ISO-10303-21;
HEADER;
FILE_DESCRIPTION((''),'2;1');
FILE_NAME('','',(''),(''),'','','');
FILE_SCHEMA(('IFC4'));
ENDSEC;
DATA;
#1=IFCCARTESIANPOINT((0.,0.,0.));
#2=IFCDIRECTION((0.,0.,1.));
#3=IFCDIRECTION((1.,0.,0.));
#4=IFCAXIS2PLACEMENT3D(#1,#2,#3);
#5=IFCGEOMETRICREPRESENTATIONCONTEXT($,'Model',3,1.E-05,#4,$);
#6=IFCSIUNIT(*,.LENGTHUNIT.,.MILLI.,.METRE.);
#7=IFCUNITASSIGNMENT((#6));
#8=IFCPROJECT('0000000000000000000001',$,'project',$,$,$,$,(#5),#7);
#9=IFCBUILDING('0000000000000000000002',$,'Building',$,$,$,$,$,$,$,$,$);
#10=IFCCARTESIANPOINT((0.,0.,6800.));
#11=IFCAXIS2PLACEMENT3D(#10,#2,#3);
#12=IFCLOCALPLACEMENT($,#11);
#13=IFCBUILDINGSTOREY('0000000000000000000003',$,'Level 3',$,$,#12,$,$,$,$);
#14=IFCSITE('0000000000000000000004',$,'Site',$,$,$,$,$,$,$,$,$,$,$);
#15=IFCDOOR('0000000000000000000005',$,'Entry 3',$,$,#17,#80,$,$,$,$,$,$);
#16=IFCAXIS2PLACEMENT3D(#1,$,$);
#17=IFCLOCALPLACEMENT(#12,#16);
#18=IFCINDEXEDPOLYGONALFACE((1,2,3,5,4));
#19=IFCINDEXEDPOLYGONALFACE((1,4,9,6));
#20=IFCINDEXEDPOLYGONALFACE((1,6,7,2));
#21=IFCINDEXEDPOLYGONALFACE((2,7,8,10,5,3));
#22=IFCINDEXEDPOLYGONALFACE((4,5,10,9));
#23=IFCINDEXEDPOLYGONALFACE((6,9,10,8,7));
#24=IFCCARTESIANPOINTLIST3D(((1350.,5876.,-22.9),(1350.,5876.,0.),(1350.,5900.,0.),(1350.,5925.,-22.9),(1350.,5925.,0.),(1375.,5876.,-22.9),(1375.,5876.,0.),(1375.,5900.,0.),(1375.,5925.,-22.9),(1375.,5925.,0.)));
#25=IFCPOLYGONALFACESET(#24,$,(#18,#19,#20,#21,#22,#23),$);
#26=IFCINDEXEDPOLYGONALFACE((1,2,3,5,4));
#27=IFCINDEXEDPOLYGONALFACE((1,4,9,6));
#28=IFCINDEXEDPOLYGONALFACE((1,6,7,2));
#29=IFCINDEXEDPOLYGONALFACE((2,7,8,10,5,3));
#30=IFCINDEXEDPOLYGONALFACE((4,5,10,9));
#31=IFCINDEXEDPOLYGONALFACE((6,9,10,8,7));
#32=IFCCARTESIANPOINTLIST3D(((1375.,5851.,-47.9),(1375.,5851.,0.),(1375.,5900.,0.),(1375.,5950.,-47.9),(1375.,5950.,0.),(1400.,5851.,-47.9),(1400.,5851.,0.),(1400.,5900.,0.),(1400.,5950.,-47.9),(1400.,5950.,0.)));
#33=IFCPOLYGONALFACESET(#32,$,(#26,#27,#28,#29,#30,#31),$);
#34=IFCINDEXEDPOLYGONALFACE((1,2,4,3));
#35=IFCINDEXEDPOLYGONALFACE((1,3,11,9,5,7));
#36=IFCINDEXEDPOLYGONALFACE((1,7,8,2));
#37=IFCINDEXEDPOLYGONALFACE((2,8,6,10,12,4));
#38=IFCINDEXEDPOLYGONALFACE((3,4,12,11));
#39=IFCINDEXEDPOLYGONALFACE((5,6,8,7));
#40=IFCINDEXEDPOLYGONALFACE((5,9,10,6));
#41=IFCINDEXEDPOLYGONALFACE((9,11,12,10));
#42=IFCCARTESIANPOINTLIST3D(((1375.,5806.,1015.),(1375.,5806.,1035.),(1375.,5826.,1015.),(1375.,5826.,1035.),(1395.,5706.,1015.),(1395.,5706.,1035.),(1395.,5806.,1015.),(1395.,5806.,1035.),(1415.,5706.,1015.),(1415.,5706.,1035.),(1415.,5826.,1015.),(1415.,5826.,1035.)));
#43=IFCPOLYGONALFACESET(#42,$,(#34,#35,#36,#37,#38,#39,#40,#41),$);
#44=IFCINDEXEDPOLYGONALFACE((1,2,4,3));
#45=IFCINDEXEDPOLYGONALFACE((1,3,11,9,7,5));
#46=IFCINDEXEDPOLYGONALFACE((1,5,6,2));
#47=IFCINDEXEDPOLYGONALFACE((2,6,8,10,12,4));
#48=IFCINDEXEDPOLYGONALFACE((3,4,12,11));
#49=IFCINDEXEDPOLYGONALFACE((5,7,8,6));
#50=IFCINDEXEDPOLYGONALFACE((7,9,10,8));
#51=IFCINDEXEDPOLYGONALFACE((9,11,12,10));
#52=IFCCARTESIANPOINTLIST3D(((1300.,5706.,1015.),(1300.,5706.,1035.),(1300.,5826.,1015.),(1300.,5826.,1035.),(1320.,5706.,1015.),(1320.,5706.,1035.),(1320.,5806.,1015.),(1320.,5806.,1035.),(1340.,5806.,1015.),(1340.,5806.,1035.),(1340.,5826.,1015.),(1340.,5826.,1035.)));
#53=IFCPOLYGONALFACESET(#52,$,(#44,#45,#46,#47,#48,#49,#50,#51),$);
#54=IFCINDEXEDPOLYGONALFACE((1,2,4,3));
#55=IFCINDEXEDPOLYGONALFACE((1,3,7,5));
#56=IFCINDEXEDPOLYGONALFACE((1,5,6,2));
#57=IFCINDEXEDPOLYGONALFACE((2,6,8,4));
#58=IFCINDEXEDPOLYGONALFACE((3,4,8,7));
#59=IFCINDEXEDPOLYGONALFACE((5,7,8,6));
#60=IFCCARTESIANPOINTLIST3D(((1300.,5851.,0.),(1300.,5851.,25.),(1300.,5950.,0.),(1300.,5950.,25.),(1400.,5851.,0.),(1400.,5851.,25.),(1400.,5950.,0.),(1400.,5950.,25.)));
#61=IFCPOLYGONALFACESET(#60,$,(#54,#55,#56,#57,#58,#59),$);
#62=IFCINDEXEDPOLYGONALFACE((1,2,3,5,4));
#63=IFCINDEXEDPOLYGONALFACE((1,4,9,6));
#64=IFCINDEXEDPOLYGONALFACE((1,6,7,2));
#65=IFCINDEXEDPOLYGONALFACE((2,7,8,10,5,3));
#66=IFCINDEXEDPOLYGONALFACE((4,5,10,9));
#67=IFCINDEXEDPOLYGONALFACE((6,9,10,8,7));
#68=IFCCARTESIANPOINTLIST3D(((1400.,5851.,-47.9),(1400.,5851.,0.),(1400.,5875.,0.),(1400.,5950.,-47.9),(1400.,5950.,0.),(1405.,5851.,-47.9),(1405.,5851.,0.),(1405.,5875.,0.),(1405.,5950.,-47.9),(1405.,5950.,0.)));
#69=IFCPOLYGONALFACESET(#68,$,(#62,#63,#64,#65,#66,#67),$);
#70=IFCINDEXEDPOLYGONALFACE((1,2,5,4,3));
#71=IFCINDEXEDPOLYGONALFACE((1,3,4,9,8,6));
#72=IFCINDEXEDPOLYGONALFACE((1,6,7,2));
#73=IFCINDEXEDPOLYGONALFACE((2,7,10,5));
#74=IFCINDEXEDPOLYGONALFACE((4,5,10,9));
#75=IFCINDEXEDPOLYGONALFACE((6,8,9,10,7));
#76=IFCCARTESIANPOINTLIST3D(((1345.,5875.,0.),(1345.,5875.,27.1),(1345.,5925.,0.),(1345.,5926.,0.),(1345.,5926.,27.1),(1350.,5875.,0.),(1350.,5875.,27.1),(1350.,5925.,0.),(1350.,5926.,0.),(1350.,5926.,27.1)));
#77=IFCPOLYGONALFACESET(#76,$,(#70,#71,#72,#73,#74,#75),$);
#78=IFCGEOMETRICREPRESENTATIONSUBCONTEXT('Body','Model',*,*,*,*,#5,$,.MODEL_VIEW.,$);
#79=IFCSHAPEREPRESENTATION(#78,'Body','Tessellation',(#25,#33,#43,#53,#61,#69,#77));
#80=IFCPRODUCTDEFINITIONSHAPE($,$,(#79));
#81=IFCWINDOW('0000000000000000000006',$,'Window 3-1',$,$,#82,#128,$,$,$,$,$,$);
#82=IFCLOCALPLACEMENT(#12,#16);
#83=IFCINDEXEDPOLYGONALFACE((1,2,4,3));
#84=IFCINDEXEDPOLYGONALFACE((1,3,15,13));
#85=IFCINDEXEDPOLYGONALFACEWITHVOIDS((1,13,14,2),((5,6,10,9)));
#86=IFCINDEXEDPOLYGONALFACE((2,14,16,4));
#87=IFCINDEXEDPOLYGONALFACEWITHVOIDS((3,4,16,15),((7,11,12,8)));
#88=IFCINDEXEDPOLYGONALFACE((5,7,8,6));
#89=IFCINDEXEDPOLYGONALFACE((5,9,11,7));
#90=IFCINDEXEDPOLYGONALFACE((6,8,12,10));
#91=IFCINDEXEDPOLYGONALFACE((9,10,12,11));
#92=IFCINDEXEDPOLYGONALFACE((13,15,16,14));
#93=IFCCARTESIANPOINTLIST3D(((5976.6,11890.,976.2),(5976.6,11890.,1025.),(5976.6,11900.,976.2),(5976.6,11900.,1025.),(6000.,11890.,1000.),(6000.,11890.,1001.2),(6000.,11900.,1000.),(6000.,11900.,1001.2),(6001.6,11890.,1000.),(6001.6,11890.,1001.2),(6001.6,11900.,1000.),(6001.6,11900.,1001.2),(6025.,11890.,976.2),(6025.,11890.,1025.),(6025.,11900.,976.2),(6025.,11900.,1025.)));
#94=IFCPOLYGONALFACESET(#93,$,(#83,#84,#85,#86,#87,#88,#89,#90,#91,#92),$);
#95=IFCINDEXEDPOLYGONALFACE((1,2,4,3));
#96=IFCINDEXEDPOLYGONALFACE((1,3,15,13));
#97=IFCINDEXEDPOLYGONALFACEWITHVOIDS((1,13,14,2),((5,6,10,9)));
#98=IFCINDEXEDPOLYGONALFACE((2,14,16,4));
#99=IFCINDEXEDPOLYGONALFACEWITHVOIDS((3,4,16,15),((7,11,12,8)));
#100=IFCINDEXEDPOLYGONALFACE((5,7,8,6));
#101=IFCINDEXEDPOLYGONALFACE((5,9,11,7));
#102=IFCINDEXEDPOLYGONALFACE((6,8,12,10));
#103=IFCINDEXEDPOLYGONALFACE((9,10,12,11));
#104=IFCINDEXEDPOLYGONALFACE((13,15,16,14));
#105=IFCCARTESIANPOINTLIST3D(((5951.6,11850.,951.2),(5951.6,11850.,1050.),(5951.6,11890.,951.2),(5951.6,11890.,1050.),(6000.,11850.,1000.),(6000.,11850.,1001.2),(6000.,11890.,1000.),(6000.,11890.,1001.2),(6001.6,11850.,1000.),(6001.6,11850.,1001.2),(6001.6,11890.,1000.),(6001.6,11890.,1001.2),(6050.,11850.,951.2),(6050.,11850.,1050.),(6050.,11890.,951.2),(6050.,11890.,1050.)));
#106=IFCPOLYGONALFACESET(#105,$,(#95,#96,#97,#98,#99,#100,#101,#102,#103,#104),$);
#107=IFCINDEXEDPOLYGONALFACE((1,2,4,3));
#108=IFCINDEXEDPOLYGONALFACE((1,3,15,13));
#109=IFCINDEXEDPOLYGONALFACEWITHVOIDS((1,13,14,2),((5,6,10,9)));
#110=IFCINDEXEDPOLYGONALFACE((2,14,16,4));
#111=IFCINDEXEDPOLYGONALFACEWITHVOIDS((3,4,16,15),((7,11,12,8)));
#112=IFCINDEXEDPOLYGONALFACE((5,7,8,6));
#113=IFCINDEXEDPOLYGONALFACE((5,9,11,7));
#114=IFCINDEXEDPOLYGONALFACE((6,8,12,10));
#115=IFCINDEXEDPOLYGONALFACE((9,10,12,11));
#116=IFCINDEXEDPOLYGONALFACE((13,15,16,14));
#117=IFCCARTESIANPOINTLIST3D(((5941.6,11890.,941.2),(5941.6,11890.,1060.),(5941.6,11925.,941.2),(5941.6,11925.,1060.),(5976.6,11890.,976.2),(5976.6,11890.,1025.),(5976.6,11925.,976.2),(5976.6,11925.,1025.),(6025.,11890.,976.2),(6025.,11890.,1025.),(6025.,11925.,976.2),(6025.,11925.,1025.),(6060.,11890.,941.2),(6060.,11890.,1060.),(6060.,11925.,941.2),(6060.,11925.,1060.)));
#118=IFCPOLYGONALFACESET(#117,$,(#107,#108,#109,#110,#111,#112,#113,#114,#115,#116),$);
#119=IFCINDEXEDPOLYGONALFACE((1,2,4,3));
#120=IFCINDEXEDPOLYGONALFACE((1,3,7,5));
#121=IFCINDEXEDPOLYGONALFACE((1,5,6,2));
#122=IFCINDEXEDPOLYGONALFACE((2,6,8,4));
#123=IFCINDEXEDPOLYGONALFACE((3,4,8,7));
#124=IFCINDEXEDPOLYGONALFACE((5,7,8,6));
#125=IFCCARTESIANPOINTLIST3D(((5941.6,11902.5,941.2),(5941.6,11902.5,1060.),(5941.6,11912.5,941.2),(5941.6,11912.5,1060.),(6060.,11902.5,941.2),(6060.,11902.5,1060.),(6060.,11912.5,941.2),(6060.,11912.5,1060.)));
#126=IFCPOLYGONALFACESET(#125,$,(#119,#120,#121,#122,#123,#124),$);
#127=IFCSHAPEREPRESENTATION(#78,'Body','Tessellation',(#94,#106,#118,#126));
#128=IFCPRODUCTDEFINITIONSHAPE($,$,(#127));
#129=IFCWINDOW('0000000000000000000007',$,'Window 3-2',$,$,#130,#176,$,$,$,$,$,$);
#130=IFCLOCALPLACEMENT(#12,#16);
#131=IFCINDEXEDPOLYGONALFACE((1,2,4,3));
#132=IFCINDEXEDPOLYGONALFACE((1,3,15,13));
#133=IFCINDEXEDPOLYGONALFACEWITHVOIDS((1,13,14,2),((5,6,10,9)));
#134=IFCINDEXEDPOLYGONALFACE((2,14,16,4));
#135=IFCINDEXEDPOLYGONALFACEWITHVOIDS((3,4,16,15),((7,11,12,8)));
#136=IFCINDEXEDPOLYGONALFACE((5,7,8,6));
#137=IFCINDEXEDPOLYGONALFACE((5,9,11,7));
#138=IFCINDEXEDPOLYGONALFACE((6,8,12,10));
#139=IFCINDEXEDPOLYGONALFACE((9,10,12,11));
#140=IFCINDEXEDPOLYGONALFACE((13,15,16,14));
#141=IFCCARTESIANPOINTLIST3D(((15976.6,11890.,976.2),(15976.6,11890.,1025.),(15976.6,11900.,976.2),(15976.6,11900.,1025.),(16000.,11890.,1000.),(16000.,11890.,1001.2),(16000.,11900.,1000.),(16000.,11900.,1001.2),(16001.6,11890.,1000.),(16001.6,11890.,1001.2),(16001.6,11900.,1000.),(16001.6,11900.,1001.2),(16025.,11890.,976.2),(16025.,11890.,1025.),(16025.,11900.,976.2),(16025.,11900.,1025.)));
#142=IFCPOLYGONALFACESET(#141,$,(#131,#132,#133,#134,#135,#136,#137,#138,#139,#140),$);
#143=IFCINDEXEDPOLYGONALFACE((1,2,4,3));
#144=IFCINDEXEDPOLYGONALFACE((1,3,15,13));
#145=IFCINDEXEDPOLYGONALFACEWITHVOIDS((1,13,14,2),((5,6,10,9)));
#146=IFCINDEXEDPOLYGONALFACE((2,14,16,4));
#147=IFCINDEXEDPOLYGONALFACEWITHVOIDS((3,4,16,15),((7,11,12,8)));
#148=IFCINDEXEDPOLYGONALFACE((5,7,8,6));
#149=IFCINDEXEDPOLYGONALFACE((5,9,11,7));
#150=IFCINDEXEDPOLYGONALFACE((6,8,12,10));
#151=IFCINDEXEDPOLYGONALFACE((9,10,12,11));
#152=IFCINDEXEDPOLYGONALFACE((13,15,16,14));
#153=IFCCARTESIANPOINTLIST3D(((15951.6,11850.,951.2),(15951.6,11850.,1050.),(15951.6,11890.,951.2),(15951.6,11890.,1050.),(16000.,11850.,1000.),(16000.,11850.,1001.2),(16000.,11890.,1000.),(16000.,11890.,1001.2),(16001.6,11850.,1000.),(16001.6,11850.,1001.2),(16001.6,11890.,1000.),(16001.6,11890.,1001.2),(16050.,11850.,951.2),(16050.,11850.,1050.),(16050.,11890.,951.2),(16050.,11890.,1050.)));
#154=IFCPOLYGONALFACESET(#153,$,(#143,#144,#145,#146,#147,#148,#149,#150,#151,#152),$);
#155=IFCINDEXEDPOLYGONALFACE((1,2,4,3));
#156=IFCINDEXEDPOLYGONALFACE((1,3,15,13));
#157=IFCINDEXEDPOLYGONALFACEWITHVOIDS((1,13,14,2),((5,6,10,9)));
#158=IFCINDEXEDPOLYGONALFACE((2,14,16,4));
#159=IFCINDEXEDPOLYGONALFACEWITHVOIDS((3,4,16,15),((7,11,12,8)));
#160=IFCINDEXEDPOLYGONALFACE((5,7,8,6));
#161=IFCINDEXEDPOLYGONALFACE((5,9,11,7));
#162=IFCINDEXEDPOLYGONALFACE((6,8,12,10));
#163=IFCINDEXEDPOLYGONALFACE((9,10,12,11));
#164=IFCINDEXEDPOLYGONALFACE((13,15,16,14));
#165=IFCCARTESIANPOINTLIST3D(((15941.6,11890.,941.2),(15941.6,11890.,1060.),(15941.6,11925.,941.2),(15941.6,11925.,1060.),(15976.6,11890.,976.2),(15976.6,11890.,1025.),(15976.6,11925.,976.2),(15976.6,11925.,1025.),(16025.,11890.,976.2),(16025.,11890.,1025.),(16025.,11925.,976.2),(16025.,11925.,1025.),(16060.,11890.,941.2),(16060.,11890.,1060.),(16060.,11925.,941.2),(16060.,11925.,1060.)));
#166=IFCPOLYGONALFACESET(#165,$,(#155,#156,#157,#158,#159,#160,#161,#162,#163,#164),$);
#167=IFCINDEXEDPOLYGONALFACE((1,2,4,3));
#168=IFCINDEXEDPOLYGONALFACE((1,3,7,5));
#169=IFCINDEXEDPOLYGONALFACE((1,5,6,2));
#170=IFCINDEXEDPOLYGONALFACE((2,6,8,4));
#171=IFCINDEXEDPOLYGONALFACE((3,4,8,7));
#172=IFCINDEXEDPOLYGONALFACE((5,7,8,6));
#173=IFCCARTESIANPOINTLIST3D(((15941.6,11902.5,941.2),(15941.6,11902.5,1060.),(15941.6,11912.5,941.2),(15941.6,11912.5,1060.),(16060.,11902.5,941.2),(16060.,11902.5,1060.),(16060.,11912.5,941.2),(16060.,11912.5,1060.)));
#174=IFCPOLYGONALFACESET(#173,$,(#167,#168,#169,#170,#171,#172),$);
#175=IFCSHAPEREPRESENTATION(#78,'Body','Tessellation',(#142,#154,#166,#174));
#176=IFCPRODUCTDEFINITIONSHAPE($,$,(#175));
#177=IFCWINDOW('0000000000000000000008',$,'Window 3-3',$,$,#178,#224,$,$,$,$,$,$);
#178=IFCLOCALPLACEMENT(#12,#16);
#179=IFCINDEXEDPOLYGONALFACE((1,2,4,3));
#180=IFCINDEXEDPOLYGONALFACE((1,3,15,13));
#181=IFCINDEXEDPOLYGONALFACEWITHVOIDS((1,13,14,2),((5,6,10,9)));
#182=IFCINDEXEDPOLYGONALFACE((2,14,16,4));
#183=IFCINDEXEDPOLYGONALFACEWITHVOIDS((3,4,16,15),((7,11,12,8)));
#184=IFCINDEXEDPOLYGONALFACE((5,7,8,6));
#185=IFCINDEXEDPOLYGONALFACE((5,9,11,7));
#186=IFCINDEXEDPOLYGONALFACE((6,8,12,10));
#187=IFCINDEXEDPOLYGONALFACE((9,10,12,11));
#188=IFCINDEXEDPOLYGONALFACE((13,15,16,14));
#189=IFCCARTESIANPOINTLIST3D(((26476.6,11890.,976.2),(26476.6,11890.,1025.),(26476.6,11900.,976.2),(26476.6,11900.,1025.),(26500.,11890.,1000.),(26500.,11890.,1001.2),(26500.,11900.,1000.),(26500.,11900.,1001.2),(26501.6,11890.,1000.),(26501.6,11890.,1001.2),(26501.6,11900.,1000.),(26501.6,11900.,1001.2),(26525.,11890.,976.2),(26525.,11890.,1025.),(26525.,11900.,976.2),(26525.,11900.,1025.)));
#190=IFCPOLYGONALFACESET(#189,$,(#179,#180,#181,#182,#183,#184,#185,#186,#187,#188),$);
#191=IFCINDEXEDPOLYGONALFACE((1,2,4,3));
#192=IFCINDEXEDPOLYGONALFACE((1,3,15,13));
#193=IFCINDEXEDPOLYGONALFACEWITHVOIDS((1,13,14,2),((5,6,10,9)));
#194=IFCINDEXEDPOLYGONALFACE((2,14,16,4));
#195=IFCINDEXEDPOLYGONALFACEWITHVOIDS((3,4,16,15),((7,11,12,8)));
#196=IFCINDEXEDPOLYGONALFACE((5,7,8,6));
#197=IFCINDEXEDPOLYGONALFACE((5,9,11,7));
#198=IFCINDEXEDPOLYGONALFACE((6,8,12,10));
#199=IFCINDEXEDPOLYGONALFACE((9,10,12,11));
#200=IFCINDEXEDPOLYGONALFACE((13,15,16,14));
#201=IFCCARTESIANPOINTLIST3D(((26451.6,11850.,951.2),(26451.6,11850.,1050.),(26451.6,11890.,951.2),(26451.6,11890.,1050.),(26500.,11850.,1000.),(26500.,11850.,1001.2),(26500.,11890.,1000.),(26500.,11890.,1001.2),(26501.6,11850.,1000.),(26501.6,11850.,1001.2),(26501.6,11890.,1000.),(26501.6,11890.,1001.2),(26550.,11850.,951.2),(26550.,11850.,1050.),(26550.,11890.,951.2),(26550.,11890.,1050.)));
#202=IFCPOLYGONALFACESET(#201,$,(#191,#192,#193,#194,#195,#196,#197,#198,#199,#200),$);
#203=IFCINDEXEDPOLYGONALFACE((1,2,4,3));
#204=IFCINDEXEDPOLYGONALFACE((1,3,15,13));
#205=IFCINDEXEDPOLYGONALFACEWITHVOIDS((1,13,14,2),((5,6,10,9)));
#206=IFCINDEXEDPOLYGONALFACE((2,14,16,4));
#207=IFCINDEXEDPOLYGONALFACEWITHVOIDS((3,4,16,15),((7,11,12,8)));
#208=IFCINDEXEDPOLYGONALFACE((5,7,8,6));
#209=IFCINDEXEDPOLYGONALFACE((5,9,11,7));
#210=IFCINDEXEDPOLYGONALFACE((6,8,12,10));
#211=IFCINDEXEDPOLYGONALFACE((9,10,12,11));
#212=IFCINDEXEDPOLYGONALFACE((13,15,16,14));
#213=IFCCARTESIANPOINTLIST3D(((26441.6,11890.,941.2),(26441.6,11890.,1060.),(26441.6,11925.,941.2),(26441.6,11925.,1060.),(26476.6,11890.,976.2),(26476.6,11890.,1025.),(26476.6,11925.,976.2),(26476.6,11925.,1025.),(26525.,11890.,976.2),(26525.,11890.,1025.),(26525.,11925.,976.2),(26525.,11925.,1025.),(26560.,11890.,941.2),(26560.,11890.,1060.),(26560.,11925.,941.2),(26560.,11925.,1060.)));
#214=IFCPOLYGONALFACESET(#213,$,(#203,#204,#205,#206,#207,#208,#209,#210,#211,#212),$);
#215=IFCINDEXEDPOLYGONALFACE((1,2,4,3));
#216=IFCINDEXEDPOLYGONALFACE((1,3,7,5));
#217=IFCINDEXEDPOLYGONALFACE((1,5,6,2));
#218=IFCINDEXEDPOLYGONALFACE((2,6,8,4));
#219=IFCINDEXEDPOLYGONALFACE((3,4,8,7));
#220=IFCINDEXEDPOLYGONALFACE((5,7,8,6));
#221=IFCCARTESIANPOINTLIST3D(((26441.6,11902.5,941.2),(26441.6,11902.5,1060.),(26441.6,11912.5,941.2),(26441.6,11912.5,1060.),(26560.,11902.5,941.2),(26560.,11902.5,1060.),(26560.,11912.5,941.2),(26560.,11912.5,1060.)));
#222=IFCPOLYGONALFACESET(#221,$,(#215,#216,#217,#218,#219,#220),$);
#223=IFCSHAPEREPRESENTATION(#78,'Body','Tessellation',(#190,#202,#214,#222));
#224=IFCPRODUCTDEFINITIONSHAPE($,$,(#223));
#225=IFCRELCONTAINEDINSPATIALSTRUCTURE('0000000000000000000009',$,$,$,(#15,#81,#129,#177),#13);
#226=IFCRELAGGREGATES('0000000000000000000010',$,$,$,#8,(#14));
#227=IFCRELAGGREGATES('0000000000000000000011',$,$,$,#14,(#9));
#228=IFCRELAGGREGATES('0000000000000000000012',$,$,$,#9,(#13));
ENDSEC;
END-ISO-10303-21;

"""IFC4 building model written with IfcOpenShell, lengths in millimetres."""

from ifc_helpers import new_model, si_unit, frame, origin_with_axes, place, context, subcontext, project, spatial, line, indexed_curve, outline, extrude, element, save


model = new_model("IFC4")

# Units and contexts
model_context = context("Model", 3, precision=1e-05, world=origin_with_axes())
body_context = subcontext(model_context, "Body", "Model", "MODEL_VIEW")
ifc_project = project(units=[si_unit("LENGTHUNIT", "METRE", prefix="MILLI")], contexts=[model_context])

# Site, building, storey
site = spatial("IfcSite", under=ifc_project, Name="Site")
building = spatial("IfcBuilding", under=site, Name="Building")
storey_placement = place(None, frame((0.0, 0.0, 6800.0), z_axis=(0.0, 0.0, 1.0), x_axis=(1.0, 0.0, 0.0)))
storey = spatial("IfcBuildingStorey", under=building, at=storey_placement, Name="Level 3")

# Door
door_1_placement = place(storey_placement, frame((1400.0, 5900.0, 0.0), z_axis=(0.0, 0.0, 1.0), x_axis=(0.0, 1.0, 0.0)))
element("IfcDoor", 1, at=door_1_placement, inside=storey, Name="Entry 3", context=body_context, shape_type="SweptSolid", body=[
    extrude(outline(indexed_curve([(0.0, 0.0), (0.0, 2.1), (1.0, 2.1), (1.0, 0.0), (-24.0, 0.0), (-24.0, -22.9), (25.0, -22.9), (25.0, 0.0)], segments=[line(1, 2, 3, 4, 5, 6, 7, 8, 1)])), frame((0.0, 25.0, 0.0), z_axis=(0.0, -1.0, 0.0), x_axis=(1.0, 0.0, 0.0)), (0.0, 0.0, -1.0), 25.0),
    extrude(outline(indexed_curve([(0.0, 0.0), (0.0, 2.1), (1.0, 2.1), (1.0, 0.0), (-49.0, 0.0), (-49.0, -47.9), (50.0, -47.9), (50.0, 0.0)], segments=[line(1, 2, 3, 4, 5, 6, 7, 8, 1)])), frame((0.0, 0.0, 0.0), z_axis=(0.0, -1.0, 0.0), x_axis=(1.0, 0.0, 0.0)), (0.0, 0.0, -1.0), 25.0),
    extrude(outline(indexed_curve([(0.0, 0.0), (-49.0, 0.0), (-49.0, 35.0), (0.0, 35.0)], segments=[line(1, 2, 3, 4, 1)])), frame((25.0, 25.0, 25.0), z_axis=(0.0, 0.0, 1.0), x_axis=(1.0, 0.0, 0.0)), (0.0, 0.0, 1.0), -47.9),
    extrude(outline(indexed_curve([(0.0, 0.0), (0.0, -40.0), (-120.0, -40.0), (-120.0, -20.0), (-20.0, -20.0), (-20.0, 0.0)], segments=[line(1, 2, 3, 4, 5, 6, 1)])), frame((-74.0, 25.0, 1015.0), z_axis=(0.0, 0.0, 1.0), x_axis=(1.0, 0.0, 0.0)), (0.0, 0.0, 1.0), 20.0),
    extrude(outline(indexed_curve([(0.0, 0.0), (0.0, 40.0), (-120.0, 40.0), (-120.0, 20.0), (-20.0, 20.0), (-20.0, 0.0)], segments=[line(1, 2, 3, 4, 5, 6, 1)])), frame((-74.0, 60.0, 1015.0), z_axis=(0.0, 0.0, 1.0), x_axis=(1.0, 0.0, 0.0)), (0.0, 0.0, 1.0), 20.0),
    extrude(outline(indexed_curve([(0.0, 0.0), (-99.0, 0.0), (-99.0, 100.0), (0.0, 100.0)], segments=[line(1, 2, 3, 4, 1)])), frame((50.0, 0.0, 0.0), z_axis=(0.0, 0.0, 1.0), x_axis=(1.0, 0.0, 0.0)), (0.0, 0.0, 1.0), 25.0),
    extrude(outline(indexed_curve([(0.0, 0.0), (0.0, 27.1), (51.0, 27.1), (51.0, 0.0), (-24.0, 0.0), (-24.0, -47.9), (75.0, -47.9), (75.0, 0.0)], segments=[line(1, 2, 3, 4, 5, 6, 7, 8, 1)])), frame((-25.0, -5.0, 0.0), z_axis=(0.0, -1.0, 0.0), x_axis=(1.0, 0.0, 0.0)), (0.0, 0.0, -1.0), 5.0),
    extrude(outline(indexed_curve([(0.0, 0.0), (0.0, 27.1), (51.0, 27.1), (51.0, 0.0), (1.0, 0.0), (1.0, -22.9), (50.0, -22.9), (50.0, 0.0)], segments=[line(1, 2, 3, 4, 5, 6, 7, 8, 1)])), frame((-25.0, 50.0, 0.0), z_axis=(0.0, -1.0, 0.0), x_axis=(1.0, 0.0, 0.0)), (0.0, 0.0, -1.0), 5.0),
])

# Windows
for number, where, z_axis, x_axis, name in (
    (2, (6000.0, 11800.0, 1000.0), (0.0, 0.0, 1.0), (1.0, 0.0, 0.0), "Window 3-1"),
    (3, (16000.0, 11800.0, 1000.0), (0.0, 0.0, 1.0), (1.0, 0.0, 0.0), "Window 3-2"),
    (4, (26500.0, 11800.0, 1000.0), (0.0, 0.0, 1.0), (1.0, 0.0, 0.0), "Window 3-3"),
):
    element("IfcWindow", number, at=place(storey_placement, frame(where, z_axis=z_axis, x_axis=x_axis)), inside=storey, Name=name, context=body_context, shape_type="SweptSolid", body=[
        extrude(outline(indexed_curve([(0.0, 0.0), (1.6, 0.0), (1.6, 1.2), (0.0, 1.2)], segments=[line(1, 2, 3, 4, 1)]), holes=[indexed_curve([(25.0, 25.0), (-23.4, 25.0), (-23.4, -23.8), (25.0, -23.8)], segments=[line(1, 2, 3, 4, 1)])]), frame((0.0, 90.0, 0.0), z_axis=(0.0, -1.0, 0.0), x_axis=(1.0, 0.0, 0.0)), (0.0, 0.0, -1.0), 10.0),
        extrude(outline(indexed_curve([(0.0, 0.0), (1.6, 0.0), (1.6, 1.2), (0.0, 1.2)], segments=[line(1, 2, 3, 4, 1)]), holes=[indexed_curve([(50.0, 50.0), (-48.4, 50.0), (-48.4, -48.8), (50.0, -48.8)], segments=[line(1, 2, 3, 4, 1)])]), frame((0.0, 50.0, 0.0), z_axis=(0.0, -1.0, 0.0), x_axis=(1.0, 0.0, 0.0)), (0.0, 0.0, -1.0), 40.0),
        extrude(outline(indexed_curve([(0.0, 0.0), (-48.4, 0.0), (-48.4, -48.8), (0.0, -48.8)], segments=[line(1, 2, 3, 4, 1)]), holes=[indexed_curve([(35.0, 35.0), (-83.4, 35.0), (-83.4, -83.8), (35.0, -83.8)], segments=[line(1, 2, 3, 4, 1)])]), frame((25.0, 90.0, 25.0), z_axis=(0.0, -1.0, 0.0), x_axis=(1.0, 0.0, 0.0)), (0.0, 0.0, -1.0), 35.0),
        extrude(outline(indexed_curve([(35.0, 35.0), (-83.4, 35.0), (-83.4, -83.8), (35.0, -83.8)], segments=[line(1, 2, 3, 4, 1)])), frame((25.0, 102.5, 25.0), z_axis=(0.0, -1.0, 0.0), x_axis=(1.0, 0.0, 0.0)), (0.0, 0.0, -1.0), 10.0),
    ])

save(model, "model.ifc")
